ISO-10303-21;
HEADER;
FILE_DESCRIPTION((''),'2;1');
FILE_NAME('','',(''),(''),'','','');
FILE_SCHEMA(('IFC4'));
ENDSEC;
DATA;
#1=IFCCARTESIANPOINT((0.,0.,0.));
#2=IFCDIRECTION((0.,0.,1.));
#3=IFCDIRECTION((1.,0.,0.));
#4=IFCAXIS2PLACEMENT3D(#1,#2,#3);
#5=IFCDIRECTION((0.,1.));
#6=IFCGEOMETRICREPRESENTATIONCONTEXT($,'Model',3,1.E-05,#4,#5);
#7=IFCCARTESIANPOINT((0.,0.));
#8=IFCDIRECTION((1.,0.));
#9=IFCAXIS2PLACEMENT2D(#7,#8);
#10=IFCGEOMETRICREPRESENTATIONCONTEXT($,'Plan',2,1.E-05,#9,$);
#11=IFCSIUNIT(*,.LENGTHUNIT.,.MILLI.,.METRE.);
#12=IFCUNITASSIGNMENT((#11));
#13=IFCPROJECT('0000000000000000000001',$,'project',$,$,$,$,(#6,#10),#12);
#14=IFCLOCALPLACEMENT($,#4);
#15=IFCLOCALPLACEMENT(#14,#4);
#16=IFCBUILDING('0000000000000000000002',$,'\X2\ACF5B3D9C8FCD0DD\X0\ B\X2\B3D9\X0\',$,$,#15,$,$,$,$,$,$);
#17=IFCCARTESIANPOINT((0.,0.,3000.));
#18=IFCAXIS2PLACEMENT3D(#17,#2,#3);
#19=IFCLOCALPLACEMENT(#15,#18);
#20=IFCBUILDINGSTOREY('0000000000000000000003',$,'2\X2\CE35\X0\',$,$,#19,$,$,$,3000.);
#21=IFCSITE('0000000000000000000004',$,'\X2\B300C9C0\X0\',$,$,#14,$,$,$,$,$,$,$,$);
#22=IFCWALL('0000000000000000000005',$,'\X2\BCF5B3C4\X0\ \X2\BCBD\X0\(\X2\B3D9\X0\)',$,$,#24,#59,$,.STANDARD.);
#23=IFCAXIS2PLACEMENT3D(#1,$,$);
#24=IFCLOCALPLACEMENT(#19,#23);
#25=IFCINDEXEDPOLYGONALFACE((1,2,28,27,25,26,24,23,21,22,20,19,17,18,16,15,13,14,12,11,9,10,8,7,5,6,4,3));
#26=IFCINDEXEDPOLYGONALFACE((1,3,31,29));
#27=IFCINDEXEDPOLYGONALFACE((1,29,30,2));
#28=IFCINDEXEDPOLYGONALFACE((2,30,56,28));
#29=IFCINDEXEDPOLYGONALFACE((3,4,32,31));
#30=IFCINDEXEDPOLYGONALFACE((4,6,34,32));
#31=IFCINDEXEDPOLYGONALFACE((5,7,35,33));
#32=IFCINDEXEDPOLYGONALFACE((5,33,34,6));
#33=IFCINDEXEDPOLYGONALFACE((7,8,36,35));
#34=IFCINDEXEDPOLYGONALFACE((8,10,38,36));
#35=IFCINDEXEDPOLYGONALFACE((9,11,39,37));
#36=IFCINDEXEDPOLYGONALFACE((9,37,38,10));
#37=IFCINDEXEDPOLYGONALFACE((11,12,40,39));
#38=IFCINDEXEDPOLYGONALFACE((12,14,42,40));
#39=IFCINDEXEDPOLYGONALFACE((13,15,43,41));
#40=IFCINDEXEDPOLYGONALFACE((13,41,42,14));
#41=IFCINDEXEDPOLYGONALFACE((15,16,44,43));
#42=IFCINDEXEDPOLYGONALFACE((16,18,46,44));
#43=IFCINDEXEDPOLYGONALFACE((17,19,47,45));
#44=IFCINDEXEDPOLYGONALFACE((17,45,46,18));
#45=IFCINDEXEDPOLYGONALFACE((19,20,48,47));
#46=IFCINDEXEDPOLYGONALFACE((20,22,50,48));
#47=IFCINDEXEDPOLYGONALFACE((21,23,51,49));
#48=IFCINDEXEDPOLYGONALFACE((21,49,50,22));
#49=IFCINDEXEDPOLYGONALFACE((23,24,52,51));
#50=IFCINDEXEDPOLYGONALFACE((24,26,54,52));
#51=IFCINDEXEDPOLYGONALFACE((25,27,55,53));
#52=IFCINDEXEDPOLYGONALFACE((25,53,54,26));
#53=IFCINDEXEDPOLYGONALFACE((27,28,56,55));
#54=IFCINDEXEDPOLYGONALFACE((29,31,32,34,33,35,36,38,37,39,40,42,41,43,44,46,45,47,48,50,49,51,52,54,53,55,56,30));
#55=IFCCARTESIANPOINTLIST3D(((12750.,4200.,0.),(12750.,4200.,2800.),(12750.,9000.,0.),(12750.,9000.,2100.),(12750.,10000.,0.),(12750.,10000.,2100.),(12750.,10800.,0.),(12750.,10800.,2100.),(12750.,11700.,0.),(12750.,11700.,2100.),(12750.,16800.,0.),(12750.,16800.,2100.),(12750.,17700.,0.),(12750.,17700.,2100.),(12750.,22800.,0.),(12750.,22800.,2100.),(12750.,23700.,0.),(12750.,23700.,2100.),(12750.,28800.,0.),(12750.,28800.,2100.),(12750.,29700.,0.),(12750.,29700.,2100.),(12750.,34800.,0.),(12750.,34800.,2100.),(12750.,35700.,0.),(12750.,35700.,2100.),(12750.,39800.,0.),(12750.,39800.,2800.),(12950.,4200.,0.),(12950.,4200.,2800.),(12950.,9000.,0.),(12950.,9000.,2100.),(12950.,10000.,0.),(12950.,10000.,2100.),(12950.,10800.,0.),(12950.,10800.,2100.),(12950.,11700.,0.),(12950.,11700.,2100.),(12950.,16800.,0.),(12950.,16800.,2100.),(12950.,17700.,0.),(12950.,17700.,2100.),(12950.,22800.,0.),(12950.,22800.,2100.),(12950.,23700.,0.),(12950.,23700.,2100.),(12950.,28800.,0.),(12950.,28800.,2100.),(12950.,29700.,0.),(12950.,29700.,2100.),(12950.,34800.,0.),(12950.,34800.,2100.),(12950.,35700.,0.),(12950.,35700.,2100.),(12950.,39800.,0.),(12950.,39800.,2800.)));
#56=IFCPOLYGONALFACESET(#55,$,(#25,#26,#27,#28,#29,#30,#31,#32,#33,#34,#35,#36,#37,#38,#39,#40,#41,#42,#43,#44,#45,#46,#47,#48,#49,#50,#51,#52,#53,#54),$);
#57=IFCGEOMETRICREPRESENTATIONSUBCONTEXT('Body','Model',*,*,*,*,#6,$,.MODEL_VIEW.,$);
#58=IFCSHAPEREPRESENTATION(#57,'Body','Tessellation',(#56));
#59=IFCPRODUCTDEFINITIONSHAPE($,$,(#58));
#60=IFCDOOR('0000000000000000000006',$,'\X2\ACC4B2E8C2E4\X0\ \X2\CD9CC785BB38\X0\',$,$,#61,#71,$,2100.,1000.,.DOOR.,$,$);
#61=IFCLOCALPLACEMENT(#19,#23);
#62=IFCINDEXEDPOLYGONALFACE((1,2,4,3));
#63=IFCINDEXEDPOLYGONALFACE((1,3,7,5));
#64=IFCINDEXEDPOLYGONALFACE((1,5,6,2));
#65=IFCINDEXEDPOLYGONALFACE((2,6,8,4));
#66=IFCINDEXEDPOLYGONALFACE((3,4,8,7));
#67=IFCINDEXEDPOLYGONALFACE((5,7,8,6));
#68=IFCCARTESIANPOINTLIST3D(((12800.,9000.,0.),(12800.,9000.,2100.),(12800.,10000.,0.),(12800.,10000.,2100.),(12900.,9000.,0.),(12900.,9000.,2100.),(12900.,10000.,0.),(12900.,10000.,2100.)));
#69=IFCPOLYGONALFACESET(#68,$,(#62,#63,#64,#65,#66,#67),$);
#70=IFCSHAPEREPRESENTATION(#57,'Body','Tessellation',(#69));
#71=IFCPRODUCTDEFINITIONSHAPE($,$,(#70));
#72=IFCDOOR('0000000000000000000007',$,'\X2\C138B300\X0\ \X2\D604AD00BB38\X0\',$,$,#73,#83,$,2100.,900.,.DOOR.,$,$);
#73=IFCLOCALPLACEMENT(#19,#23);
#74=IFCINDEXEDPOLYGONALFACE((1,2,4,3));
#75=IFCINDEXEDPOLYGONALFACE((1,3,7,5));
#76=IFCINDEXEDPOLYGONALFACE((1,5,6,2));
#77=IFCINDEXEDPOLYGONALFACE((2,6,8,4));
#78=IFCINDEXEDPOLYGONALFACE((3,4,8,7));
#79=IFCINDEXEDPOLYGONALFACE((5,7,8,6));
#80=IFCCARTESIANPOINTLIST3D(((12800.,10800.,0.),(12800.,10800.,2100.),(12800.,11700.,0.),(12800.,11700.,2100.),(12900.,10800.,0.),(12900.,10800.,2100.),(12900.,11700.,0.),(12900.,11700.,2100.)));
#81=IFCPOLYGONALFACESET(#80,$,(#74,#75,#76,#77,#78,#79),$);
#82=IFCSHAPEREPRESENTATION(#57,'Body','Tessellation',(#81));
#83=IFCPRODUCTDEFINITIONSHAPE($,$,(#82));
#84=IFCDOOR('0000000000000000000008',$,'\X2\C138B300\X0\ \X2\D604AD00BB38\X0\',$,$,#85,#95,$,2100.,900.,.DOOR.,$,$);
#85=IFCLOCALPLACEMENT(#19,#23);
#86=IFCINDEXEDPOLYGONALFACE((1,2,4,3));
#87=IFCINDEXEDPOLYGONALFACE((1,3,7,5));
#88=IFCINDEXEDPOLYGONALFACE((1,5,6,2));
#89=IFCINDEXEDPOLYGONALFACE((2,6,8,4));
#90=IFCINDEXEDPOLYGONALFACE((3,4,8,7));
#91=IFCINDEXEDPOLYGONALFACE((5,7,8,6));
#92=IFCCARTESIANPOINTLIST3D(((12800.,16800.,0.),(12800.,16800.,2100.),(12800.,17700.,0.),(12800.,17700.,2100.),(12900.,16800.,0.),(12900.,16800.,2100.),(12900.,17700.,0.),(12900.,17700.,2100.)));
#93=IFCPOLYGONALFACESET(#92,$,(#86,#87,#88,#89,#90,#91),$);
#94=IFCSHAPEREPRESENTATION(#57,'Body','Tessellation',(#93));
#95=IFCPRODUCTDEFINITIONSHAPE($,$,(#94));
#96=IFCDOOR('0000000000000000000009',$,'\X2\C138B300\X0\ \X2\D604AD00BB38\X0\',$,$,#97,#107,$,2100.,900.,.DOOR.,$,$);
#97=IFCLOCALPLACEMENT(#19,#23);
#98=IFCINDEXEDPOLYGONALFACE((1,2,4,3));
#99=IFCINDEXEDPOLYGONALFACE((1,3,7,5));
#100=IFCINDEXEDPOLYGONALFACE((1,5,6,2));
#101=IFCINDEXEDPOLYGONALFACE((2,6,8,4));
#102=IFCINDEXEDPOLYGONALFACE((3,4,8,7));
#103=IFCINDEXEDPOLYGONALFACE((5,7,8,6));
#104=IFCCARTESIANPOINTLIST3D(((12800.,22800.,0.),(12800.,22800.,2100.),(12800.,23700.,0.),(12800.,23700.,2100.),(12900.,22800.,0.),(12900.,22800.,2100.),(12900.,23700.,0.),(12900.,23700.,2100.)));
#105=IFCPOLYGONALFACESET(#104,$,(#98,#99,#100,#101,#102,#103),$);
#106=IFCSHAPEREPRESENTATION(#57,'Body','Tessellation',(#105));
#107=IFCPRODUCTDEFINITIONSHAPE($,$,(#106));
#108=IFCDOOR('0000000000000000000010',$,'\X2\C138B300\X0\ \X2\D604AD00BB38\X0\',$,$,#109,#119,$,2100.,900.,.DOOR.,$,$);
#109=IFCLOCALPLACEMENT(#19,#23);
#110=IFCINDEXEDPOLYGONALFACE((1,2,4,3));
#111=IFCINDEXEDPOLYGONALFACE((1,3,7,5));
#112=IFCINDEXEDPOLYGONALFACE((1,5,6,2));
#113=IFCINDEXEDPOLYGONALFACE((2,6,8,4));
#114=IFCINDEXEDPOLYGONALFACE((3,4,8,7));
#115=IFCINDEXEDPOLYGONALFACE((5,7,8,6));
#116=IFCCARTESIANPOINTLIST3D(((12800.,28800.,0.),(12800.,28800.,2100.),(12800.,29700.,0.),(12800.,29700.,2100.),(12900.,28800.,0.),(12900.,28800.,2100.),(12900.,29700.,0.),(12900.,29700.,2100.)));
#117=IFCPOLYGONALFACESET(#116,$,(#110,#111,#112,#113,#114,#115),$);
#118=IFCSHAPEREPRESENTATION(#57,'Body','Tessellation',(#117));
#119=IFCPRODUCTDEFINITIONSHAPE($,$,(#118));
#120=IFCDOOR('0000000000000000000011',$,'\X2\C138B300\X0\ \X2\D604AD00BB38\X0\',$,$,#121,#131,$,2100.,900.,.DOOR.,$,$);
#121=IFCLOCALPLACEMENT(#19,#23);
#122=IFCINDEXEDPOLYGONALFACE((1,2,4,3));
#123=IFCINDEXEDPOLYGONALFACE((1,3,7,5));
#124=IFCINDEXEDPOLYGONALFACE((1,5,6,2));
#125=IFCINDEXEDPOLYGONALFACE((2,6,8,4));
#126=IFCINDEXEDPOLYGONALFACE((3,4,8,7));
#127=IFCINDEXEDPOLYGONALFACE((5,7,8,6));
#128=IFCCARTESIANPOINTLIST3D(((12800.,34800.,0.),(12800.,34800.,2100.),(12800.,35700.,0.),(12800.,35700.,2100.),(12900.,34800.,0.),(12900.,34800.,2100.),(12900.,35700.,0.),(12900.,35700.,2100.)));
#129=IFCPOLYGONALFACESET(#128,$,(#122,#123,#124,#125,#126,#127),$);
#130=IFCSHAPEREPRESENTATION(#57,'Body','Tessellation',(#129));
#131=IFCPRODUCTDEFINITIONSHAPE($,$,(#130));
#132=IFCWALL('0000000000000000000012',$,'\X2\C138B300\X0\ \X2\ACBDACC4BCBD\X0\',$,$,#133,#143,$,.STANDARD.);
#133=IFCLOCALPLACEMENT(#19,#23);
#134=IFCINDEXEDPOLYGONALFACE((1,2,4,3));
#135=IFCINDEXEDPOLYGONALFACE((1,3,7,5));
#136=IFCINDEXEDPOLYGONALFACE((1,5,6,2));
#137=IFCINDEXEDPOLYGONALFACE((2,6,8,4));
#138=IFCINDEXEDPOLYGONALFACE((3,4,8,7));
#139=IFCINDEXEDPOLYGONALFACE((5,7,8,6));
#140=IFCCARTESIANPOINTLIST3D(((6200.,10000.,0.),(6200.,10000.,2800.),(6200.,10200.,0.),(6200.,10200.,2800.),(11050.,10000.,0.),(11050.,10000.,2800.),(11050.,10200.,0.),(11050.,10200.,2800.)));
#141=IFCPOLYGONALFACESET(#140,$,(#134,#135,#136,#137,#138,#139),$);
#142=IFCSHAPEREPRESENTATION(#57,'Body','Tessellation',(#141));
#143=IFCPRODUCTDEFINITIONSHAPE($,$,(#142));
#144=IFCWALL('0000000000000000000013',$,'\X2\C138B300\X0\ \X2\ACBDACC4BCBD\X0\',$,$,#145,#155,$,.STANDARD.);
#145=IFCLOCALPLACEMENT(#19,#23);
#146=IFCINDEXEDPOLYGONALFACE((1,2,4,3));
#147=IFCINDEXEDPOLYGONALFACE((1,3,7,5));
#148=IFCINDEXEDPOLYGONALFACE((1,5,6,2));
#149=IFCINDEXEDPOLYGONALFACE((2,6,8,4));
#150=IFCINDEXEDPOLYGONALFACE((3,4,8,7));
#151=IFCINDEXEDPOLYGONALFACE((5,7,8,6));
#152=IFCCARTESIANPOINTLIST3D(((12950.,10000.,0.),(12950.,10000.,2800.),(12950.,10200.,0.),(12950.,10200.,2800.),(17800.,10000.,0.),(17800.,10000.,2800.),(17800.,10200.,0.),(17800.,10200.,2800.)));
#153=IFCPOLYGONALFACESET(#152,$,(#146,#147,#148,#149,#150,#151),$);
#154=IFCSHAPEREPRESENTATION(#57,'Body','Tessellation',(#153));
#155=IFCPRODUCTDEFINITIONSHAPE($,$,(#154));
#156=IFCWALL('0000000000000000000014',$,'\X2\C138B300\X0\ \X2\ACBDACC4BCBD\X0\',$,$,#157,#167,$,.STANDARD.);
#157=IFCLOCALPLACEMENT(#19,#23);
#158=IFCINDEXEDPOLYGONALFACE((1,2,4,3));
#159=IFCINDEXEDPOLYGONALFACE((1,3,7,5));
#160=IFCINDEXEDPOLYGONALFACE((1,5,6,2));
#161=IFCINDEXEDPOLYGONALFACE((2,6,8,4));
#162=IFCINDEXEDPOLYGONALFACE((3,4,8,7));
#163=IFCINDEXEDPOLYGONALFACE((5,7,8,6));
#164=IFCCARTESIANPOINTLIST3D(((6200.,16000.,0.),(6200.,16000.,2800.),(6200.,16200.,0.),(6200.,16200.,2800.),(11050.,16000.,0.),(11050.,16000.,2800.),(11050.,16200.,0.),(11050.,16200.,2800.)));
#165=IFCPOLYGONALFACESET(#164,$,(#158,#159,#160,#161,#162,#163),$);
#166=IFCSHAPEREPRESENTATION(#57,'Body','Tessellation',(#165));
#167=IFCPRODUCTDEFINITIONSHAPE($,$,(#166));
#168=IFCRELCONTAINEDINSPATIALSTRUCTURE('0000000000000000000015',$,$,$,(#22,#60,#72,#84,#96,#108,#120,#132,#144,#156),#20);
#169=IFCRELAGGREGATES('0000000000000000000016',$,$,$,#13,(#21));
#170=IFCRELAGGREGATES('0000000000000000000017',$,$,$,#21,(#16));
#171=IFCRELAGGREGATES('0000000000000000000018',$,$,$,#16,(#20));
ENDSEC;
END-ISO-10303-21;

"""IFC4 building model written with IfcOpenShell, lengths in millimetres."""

from ifc_helpers import new_model, si_unit, direction, frame, origin_with_axes, origin_2d_with_axis, place, context, subcontext, project, spatial, polyline, outline, extrude, element, fill, save


model = new_model("IFC4")

# Units and contexts
model_context = context("Model", 3, precision=1e-05, world=origin_with_axes(), true_north=direction((0.0, 1.0)))
plan_context = context("Plan", 2, precision=1e-05, world=origin_2d_with_axis())
body_context = subcontext(model_context, "Body", "Model", "MODEL_VIEW")
ifc_project = project(units=[si_unit("LENGTHUNIT", "METRE", prefix="MILLI")], contexts=[model_context, plan_context])

# Site, building, storey
site_placement = place(None, origin_with_axes())
site = spatial("IfcSite", under=ifc_project, at=site_placement, Name="대지")
building_placement = place(site_placement, origin_with_axes())
building = spatial("IfcBuilding", under=site, at=building_placement, Name="공동주택 B동")
storey_placement = place(building_placement, frame((0.0, 0.0, 3000.0), z_axis=(0.0, 0.0, 1.0), x_axis=(1.0, 0.0, 0.0)))
storey = spatial("IfcBuildingStorey", under=building, at=storey_placement, Name="2층", Elevation=3000.0)

# Wall, openings, doors
wall_1_placement = place(storey_placement, origin_with_axes())
wall_1 = element("IfcWall", 1, at=wall_1_placement, inside=storey, Name="복도 벽(동)", PredefinedType="STANDARD", context=body_context, shape_type="SweptSolid", body=[
    extrude(outline(polyline([(12750.0, 4200.0), (12750.0, 39800.0), (12950.0, 39800.0), (12950.0, 4200.0), (12750.0, 4200.0)])), origin_with_axes(), (0.0, 0.0, 1.0), 2800.0),
])
opening_1_placement = place(storey_placement, origin_with_axes())
opening_1 = element("IfcOpeningElement", 2, at=opening_1_placement, cuts=wall_1, PredefinedType="OPENING", context=body_context, shape_type="SweptSolid", body=[
    extrude(outline(polyline([(13000.0, 9000.0), (13000.0, 10000.0), (12700.0, 10000.0), (12700.0, 9000.0), (13000.0, 9000.0)])), origin_with_axes(), (0.0, 0.0, 1.0), 2100.0),
])
opening_2_placement = place(storey_placement, origin_with_axes())
opening_2 = element("IfcOpeningElement", 3, at=opening_2_placement, cuts=wall_1, PredefinedType="OPENING", context=body_context, shape_type="SweptSolid", body=[
    extrude(outline(polyline([(13000.0, 10800.0), (13000.0, 11700.0), (12700.0, 11700.0), (12700.0, 10800.0), (13000.0, 10800.0)])), origin_with_axes(), (0.0, 0.0, 1.0), 2100.0),
])
opening_3_placement = place(storey_placement, origin_with_axes())
opening_3 = element("IfcOpeningElement", 4, at=opening_3_placement, cuts=wall_1, PredefinedType="OPENING", context=body_context, shape_type="SweptSolid", body=[
    extrude(outline(polyline([(13000.0, 16800.0), (13000.0, 17700.0), (12700.0, 17700.0), (12700.0, 16800.0), (13000.0, 16800.0)])), origin_with_axes(), (0.0, 0.0, 1.0), 2100.0),
])
opening_4_placement = place(storey_placement, origin_with_axes())
opening_4 = element("IfcOpeningElement", 5, at=opening_4_placement, cuts=wall_1, PredefinedType="OPENING", context=body_context, shape_type="SweptSolid", body=[
    extrude(outline(polyline([(13000.0, 22800.0), (13000.0, 23700.0), (12700.0, 23700.0), (12700.0, 22800.0), (13000.0, 22800.0)])), origin_with_axes(), (0.0, 0.0, 1.0), 2100.0),
])
opening_5_placement = place(storey_placement, origin_with_axes())
opening_5 = element("IfcOpeningElement", 6, at=opening_5_placement, cuts=wall_1, PredefinedType="OPENING", context=body_context, shape_type="SweptSolid", body=[
    extrude(outline(polyline([(13000.0, 28800.0), (13000.0, 29700.0), (12700.0, 29700.0), (12700.0, 28800.0), (13000.0, 28800.0)])), origin_with_axes(), (0.0, 0.0, 1.0), 2100.0),
])
opening_6_placement = place(storey_placement, origin_with_axes())
opening_6 = element("IfcOpeningElement", 7, at=opening_6_placement, cuts=wall_1, PredefinedType="OPENING", context=body_context, shape_type="SweptSolid", body=[
    extrude(outline(polyline([(13000.0, 34800.0), (13000.0, 35700.0), (12700.0, 35700.0), (12700.0, 34800.0), (13000.0, 34800.0)])), origin_with_axes(), (0.0, 0.0, 1.0), 2100.0),
])
door_1_placement = place(storey_placement, origin_with_axes())
door_1 = element("IfcDoor", 8, at=door_1_placement, inside=storey, Name="계단실 출입문", OverallHeight=2100.0, OverallWidth=1000.0, PredefinedType="DOOR", context=body_context, shape_type="SweptSolid", body=[
    extrude(outline(polyline([(12900.0, 9000.0), (12900.0, 10000.0), (12800.0, 10000.0), (12800.0, 9000.0), (12900.0, 9000.0)])), origin_with_axes(), (0.0, 0.0, 1.0), 2100.0),
])
fill(opening_1, door_1)
door_2_placement = place(storey_placement, origin_with_axes())
door_2 = element("IfcDoor", 9, at=door_2_placement, inside=storey, Name="세대 현관문", OverallHeight=2100.0, OverallWidth=900.0, PredefinedType="DOOR", context=body_context, shape_type="SweptSolid", body=[
    extrude(outline(polyline([(12900.0, 10800.0), (12900.0, 11700.0), (12800.0, 11700.0), (12800.0, 10800.0), (12900.0, 10800.0)])), origin_with_axes(), (0.0, 0.0, 1.0), 2100.0),
])
fill(opening_2, door_2)
door_3_placement = place(storey_placement, origin_with_axes())
door_3 = element("IfcDoor", 10, at=door_3_placement, inside=storey, Name="세대 현관문", OverallHeight=2100.0, OverallWidth=900.0, PredefinedType="DOOR", context=body_context, shape_type="SweptSolid", body=[
    extrude(outline(polyline([(12900.0, 16800.0), (12900.0, 17700.0), (12800.0, 17700.0), (12800.0, 16800.0), (12900.0, 16800.0)])), origin_with_axes(), (0.0, 0.0, 1.0), 2100.0),
])
fill(opening_3, door_3)
door_4_placement = place(storey_placement, origin_with_axes())
door_4 = element("IfcDoor", 11, at=door_4_placement, inside=storey, Name="세대 현관문", OverallHeight=2100.0, OverallWidth=900.0, PredefinedType="DOOR", context=body_context, shape_type="SweptSolid", body=[
    extrude(outline(polyline([(12900.0, 22800.0), (12900.0, 23700.0), (12800.0, 23700.0), (12800.0, 22800.0), (12900.0, 22800.0)])), origin_with_axes(), (0.0, 0.0, 1.0), 2100.0),
])
fill(opening_4, door_4)
door_5_placement = place(storey_placement, origin_with_axes())
door_5 = element("IfcDoor", 12, at=door_5_placement, inside=storey, Name="세대 현관문", OverallHeight=2100.0, OverallWidth=900.0, PredefinedType="DOOR", context=body_context, shape_type="SweptSolid", body=[
    extrude(outline(polyline([(12900.0, 28800.0), (12900.0, 29700.0), (12800.0, 29700.0), (12800.0, 28800.0), (12900.0, 28800.0)])), origin_with_axes(), (0.0, 0.0, 1.0), 2100.0),
])
fill(opening_5, door_5)
door_6_placement = place(storey_placement, origin_with_axes())
door_6 = element("IfcDoor", 13, at=door_6_placement, inside=storey, Name="세대 현관문", OverallHeight=2100.0, OverallWidth=900.0, PredefinedType="DOOR", context=body_context, shape_type="SweptSolid", body=[
    extrude(outline(polyline([(12900.0, 34800.0), (12900.0, 35700.0), (12800.0, 35700.0), (12800.0, 34800.0), (12900.0, 34800.0)])), origin_with_axes(), (0.0, 0.0, 1.0), 2100.0),
])
fill(opening_6, door_6)

# Walls
wall_2_placement = place(storey_placement, origin_with_axes())
element("IfcWall", 14, at=wall_2_placement, inside=storey, Name="세대 경계벽", PredefinedType="STANDARD", context=body_context, shape_type="SweptSolid", body=[
    extrude(outline(polyline([(6200.0, 10200.0), (11050.0, 10200.0), (11050.0, 10000.0), (6200.0, 10000.0), (6200.0, 10200.0)])), origin_with_axes(), (0.0, 0.0, 1.0), 2800.0),
])
wall_3_placement = place(storey_placement, origin_with_axes())
element("IfcWall", 15, at=wall_3_placement, inside=storey, Name="세대 경계벽", PredefinedType="STANDARD", context=body_context, shape_type="SweptSolid", body=[
    extrude(outline(polyline([(12950.0, 10200.0), (17800.0, 10200.0), (17800.0, 10000.0), (12950.0, 10000.0), (12950.0, 10200.0)])), origin_with_axes(), (0.0, 0.0, 1.0), 2800.0),
])
wall_4_placement = place(storey_placement, origin_with_axes())
element("IfcWall", 16, at=wall_4_placement, inside=storey, Name="세대 경계벽", PredefinedType="STANDARD", context=body_context, shape_type="SweptSolid", body=[
    extrude(outline(polyline([(6200.0, 16200.0), (11050.0, 16200.0), (11050.0, 16000.0), (6200.0, 16000.0), (6200.0, 16200.0)])), origin_with_axes(), (0.0, 0.0, 1.0), 2800.0),
])

save(model, "model.ifc")
